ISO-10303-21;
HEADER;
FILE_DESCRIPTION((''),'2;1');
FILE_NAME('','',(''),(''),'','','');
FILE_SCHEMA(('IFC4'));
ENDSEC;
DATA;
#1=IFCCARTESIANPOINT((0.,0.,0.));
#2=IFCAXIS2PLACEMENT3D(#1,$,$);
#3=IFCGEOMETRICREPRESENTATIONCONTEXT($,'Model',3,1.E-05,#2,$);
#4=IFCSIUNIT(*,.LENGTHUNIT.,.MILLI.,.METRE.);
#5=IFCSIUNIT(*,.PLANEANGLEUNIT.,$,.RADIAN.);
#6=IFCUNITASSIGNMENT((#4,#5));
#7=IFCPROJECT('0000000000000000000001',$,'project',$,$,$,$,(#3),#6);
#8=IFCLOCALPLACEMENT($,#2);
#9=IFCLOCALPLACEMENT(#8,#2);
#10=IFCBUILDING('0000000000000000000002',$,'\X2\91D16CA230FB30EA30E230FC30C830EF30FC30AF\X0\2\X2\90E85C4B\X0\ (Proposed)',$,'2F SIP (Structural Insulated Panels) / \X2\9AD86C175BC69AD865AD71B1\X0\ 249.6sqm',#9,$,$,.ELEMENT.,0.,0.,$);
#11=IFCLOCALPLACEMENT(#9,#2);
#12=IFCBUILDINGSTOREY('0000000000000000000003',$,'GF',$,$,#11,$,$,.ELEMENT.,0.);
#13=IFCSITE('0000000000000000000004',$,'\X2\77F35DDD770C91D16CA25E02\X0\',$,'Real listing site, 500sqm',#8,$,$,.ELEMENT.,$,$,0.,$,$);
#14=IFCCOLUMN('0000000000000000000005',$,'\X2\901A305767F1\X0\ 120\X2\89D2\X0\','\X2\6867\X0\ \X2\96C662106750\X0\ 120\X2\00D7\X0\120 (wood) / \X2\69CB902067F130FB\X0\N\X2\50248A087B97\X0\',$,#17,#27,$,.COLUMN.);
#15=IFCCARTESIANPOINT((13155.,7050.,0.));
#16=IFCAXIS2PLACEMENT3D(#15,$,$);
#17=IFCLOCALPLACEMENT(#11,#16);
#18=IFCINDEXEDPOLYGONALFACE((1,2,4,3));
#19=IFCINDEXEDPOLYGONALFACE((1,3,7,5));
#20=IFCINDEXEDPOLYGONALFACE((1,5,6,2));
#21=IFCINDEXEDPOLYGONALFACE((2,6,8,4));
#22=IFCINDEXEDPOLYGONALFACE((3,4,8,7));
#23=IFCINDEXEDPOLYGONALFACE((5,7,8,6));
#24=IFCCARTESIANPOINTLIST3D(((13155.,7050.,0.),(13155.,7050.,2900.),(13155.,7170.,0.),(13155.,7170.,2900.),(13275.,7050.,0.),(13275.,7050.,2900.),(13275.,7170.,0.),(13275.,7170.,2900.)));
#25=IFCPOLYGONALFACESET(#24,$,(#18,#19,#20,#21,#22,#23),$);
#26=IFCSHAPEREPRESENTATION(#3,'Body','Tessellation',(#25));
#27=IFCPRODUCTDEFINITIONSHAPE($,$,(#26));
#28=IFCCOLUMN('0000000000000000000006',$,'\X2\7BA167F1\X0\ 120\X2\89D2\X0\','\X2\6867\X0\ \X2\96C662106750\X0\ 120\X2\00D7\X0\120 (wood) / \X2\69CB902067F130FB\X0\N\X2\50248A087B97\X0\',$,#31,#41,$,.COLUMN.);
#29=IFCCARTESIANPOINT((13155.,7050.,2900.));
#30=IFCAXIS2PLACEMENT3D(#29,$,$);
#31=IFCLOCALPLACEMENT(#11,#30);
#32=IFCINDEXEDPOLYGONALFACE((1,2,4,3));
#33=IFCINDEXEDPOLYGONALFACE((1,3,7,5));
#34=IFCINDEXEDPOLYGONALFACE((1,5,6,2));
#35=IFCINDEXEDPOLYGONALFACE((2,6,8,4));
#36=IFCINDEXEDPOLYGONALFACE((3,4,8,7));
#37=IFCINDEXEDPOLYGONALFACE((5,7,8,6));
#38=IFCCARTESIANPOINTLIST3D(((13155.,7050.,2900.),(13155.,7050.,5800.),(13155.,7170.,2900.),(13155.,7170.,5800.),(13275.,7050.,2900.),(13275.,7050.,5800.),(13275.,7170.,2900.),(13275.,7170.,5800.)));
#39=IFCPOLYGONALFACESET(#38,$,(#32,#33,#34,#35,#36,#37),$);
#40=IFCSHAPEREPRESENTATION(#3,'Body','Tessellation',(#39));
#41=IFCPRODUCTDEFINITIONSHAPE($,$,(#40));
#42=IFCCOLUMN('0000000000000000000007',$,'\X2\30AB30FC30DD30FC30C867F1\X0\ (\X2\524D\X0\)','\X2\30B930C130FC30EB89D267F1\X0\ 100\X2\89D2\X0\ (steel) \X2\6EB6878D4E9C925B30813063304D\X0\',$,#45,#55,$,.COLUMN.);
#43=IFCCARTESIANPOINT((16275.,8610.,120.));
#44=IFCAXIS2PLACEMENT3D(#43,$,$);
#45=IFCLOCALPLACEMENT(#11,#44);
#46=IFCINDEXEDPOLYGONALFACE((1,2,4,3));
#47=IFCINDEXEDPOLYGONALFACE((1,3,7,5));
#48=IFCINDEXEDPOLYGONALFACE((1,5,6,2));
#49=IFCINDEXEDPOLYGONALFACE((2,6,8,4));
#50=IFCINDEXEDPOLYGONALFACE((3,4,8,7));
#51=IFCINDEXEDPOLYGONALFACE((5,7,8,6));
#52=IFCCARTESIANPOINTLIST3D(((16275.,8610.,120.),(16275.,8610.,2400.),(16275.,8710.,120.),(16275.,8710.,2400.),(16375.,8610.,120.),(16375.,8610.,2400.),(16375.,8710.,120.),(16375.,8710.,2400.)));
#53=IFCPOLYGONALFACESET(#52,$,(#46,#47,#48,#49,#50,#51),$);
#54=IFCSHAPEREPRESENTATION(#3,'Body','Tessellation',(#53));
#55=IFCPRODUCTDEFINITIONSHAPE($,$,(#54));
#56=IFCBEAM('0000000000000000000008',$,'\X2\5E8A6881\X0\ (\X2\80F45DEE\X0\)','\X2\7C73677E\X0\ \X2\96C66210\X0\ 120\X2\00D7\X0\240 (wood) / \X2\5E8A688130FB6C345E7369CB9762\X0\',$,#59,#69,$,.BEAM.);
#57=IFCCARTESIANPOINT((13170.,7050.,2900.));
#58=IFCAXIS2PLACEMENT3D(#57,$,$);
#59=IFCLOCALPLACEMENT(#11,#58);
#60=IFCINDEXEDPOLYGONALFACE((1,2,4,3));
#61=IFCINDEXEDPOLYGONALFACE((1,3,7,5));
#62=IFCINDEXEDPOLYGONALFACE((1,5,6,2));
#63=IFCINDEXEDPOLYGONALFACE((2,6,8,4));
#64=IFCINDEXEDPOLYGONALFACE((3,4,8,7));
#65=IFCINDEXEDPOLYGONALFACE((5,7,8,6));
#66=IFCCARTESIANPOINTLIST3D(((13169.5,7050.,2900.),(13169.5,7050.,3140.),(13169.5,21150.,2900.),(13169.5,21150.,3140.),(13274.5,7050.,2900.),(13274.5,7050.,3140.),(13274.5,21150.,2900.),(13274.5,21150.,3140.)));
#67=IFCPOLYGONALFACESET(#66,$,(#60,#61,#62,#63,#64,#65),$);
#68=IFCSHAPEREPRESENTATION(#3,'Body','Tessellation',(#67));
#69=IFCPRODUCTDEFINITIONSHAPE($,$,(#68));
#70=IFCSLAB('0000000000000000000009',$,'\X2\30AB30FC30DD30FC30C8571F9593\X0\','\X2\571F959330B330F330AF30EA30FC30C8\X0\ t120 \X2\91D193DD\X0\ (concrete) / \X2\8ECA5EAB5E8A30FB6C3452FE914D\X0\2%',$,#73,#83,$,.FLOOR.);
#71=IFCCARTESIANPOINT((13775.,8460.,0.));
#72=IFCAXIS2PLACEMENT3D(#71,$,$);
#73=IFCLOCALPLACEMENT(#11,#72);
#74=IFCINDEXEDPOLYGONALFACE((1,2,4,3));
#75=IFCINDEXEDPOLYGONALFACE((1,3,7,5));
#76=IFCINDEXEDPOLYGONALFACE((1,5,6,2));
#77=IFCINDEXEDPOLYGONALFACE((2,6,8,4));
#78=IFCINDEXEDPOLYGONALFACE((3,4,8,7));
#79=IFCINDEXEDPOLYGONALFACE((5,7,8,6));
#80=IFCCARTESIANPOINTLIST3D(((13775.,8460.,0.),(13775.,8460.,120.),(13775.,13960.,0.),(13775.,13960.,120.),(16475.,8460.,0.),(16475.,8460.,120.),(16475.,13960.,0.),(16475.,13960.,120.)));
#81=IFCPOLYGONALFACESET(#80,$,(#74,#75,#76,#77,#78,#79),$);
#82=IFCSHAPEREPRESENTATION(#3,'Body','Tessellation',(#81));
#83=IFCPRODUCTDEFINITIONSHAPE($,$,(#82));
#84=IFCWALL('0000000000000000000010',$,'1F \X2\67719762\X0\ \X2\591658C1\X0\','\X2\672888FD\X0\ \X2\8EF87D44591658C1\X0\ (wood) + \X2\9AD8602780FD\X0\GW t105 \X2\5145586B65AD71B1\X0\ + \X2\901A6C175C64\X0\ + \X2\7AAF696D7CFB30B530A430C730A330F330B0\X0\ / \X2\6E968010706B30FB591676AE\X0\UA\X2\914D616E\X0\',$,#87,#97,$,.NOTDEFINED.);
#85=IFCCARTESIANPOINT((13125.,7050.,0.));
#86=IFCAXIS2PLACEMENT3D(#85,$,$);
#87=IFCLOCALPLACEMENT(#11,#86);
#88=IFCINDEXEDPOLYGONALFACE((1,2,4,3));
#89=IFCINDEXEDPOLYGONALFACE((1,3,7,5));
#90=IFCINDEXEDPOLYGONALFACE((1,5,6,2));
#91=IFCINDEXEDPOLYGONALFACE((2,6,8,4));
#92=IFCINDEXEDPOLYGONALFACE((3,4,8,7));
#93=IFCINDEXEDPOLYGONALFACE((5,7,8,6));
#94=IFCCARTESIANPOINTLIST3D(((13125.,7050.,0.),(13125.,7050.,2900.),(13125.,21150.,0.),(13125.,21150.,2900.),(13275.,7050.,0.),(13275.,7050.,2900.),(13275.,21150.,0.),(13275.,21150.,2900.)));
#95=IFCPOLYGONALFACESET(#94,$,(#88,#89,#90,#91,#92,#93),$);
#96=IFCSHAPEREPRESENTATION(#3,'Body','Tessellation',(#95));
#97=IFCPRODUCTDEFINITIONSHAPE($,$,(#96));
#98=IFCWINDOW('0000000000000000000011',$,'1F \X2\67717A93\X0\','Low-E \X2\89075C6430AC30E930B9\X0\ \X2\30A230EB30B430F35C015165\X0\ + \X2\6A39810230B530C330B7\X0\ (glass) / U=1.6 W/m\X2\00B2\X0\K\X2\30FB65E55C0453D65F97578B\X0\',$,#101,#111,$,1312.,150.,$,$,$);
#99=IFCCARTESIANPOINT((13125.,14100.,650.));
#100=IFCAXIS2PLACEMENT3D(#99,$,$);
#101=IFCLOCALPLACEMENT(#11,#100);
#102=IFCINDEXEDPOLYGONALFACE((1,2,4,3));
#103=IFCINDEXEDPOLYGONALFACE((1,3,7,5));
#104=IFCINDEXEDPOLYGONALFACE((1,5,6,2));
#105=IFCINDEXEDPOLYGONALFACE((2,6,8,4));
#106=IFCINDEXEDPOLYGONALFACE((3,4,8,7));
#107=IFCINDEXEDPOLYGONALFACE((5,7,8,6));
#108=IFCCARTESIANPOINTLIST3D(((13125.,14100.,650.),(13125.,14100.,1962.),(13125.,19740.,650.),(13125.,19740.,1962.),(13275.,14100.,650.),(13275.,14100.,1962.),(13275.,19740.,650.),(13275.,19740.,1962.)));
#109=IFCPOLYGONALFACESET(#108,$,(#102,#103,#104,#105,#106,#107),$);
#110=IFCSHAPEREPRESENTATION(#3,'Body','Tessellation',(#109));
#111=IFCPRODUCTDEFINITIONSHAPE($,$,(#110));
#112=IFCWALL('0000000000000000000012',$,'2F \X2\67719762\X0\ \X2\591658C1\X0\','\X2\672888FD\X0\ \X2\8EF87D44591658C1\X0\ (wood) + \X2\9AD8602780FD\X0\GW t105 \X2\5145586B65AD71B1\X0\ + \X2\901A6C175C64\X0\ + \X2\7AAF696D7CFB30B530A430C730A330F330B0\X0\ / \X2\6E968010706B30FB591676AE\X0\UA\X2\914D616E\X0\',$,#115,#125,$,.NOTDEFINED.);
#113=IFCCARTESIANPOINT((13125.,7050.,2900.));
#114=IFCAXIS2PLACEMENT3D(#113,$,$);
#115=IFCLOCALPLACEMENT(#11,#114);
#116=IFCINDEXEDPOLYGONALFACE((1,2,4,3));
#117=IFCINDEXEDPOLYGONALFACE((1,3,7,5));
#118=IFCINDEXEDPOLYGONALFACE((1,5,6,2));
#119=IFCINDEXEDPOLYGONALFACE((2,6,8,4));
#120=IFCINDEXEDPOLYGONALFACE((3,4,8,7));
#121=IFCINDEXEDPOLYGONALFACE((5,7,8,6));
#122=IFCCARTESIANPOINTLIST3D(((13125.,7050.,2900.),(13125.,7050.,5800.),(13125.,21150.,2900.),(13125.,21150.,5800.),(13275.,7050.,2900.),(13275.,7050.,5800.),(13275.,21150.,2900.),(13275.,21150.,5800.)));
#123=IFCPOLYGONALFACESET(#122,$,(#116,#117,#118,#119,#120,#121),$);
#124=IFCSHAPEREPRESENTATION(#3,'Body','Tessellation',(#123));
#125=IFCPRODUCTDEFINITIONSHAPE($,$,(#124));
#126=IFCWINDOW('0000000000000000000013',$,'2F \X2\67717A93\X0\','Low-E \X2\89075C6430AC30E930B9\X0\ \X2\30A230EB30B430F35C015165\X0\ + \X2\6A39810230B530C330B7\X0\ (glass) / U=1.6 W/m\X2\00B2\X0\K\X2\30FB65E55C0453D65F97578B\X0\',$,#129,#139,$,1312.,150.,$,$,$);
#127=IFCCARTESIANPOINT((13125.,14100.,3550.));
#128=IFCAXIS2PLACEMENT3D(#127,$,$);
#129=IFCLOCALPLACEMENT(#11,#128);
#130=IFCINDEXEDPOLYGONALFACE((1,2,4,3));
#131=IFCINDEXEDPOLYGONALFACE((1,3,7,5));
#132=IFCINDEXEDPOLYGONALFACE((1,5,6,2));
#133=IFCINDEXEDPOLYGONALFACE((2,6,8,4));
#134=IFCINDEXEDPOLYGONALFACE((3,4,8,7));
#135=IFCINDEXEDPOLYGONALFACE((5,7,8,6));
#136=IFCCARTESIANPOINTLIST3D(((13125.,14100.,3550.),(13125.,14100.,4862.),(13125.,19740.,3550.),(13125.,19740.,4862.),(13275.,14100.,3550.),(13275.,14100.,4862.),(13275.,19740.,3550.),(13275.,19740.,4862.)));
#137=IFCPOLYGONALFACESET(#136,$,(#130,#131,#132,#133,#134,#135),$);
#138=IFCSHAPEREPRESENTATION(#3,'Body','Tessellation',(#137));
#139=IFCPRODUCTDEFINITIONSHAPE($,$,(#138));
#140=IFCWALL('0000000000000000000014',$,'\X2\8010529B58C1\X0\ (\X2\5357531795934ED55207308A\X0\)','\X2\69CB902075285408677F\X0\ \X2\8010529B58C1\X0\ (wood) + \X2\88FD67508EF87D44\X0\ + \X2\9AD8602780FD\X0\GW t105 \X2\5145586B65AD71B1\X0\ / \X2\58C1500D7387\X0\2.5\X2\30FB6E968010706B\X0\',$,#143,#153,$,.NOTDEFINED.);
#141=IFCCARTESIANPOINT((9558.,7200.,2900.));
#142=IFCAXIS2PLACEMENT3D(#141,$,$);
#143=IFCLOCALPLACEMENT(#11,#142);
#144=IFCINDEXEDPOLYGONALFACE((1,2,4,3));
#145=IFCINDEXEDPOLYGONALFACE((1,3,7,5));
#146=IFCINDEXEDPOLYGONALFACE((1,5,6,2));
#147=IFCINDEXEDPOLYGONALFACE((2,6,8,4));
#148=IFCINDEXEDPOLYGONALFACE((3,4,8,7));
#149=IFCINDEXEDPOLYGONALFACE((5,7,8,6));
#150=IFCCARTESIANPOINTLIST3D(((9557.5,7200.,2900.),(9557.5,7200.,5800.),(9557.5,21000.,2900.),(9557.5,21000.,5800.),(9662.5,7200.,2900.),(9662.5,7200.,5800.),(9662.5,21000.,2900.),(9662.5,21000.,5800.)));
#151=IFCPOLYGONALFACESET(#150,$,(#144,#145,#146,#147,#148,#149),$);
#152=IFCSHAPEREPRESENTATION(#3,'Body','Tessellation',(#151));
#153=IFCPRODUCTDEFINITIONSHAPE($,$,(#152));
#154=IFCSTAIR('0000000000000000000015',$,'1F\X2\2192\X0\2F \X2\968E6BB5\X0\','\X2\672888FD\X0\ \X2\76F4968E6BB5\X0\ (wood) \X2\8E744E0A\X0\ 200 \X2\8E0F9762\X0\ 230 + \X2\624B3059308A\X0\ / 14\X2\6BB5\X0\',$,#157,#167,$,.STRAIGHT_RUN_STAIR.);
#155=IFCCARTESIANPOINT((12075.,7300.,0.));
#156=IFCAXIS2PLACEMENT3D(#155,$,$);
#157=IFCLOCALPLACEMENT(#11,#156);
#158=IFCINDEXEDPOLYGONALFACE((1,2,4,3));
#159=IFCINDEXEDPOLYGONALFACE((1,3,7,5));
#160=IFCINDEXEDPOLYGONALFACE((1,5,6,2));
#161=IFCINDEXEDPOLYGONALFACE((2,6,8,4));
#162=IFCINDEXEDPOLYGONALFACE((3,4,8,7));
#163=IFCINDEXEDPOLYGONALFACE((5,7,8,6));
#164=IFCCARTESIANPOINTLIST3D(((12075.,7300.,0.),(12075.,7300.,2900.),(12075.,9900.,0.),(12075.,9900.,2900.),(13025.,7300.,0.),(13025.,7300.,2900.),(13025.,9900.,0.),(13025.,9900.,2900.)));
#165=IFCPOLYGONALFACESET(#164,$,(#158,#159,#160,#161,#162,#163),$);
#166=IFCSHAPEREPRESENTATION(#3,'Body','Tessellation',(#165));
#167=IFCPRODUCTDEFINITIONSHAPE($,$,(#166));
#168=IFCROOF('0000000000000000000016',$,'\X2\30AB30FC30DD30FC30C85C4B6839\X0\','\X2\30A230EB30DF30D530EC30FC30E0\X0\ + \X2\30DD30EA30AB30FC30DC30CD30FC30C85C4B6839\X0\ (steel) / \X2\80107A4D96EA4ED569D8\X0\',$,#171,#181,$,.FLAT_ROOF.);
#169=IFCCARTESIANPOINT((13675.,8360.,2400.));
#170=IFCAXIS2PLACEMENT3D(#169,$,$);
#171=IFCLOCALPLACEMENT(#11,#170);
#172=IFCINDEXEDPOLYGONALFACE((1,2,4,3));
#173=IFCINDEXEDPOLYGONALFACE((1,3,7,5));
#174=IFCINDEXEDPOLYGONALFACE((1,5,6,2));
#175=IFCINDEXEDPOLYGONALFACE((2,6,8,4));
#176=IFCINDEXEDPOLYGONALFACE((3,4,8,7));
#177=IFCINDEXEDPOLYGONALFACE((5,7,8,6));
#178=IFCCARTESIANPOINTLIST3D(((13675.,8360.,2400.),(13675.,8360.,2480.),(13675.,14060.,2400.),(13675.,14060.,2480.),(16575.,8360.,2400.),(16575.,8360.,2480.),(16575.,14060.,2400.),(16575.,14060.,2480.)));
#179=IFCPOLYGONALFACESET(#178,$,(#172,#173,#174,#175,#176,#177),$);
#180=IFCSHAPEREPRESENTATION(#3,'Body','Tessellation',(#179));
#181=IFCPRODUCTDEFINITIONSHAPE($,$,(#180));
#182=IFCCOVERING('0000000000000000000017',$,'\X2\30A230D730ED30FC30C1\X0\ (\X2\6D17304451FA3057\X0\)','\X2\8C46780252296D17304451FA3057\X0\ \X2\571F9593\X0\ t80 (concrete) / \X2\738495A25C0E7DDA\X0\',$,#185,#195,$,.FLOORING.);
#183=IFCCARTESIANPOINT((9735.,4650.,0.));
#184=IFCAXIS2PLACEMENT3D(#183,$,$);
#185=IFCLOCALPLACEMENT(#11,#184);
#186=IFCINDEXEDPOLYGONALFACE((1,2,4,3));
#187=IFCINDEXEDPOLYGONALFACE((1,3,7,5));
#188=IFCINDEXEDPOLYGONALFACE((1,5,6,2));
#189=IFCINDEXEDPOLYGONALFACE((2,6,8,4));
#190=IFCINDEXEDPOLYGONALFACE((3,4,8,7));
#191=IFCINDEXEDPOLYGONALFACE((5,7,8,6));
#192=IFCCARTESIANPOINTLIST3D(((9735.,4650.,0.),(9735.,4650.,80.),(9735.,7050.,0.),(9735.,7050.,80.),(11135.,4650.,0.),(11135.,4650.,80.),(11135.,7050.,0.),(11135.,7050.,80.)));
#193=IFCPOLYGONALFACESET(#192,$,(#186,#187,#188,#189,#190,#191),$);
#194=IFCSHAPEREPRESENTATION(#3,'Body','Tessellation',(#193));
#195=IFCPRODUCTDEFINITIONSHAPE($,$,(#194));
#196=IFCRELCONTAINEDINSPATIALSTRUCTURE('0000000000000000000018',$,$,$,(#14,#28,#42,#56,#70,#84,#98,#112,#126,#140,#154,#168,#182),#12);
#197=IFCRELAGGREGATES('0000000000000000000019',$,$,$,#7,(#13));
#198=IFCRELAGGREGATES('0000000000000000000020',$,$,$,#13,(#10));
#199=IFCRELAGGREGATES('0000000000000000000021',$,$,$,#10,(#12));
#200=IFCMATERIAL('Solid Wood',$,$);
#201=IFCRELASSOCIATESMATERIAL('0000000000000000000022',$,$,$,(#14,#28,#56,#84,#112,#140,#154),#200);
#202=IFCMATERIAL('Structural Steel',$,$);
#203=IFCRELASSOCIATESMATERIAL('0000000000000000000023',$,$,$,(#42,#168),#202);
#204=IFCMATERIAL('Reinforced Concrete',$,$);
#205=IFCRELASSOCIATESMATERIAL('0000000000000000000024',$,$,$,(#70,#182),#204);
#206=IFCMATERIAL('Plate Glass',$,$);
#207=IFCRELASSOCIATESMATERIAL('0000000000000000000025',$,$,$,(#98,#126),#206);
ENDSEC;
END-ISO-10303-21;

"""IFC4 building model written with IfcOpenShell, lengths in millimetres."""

from ifc_helpers import new_model, si_unit, frame, frame_2d, origin, place, context, project, spatial, rectangle, extrude, material, element, fill, save


model = new_model("IFC4")

# Units and contexts
model_context = context("Model", 3, precision=1e-05, world=origin())
ifc_project = project(units=[si_unit("LENGTHUNIT", "METRE", prefix="MILLI"), si_unit("PLANEANGLEUNIT", "RADIAN")], contexts=[model_context])

# Site, building, storey
site_placement = place(None, origin())
site = spatial("IfcSite", under=ifc_project, at=site_placement, Name="石川県金沢市", ObjectType="Real listing site, 500sqm", CompositionType="ELEMENT", RefElevation=0.0)
building_placement = place(site_placement, origin())
building = spatial("IfcBuilding", under=site, at=building_placement, Name="金沢・リモートワーク2部屋 (Proposed)", ObjectType="2F SIP (Structural Insulated Panels) / 高気密高断熱 249.6sqm", CompositionType="ELEMENT", ElevationOfRefHeight=0.0, ElevationOfTerrain=0.0)
storey_placement = place(building_placement, origin())
storey = spatial("IfcBuildingStorey", under=building, at=storey_placement, Name="GF", CompositionType="ELEMENT", Elevation=0.0)

# Columns
ifc_material_1 = material(Name="Solid Wood")
column_1_placement = place(storey_placement, frame((13155.0, 7050.0, 0.0)))
element("IfcColumn", 1, at=column_1_placement, inside=storey, material=ifc_material_1, Name="通し柱 120角", Description="桧 集成材 120×120 (wood) / 構造柱・N値計算", PredefinedType="COLUMN", context=model_context, shape_type="SweptSolid", body=[
    extrude(rectangle(XDim=120.0, YDim=120.0, at=frame_2d((60.0, 60.0))), frame((13155.0, 7050.0, 0.0)), (0.0, 0.0, 1.0), 2900.0),
])
column_2_placement = place(storey_placement, frame((13155.0, 7050.0, 2900.0)))
element("IfcColumn", 2, at=column_2_placement, inside=storey, material=ifc_material_1, Name="管柱 120角", Description="桧 集成材 120×120 (wood) / 構造柱・N値計算", PredefinedType="COLUMN", context=model_context, shape_type="SweptSolid", body=[
    extrude(rectangle(XDim=120.0, YDim=120.0, at=frame_2d((60.0, 60.0))), frame((13155.0, 7050.0, 2900.0)), (0.0, 0.0, 1.0), 2900.0),
])
ifc_material_2 = material(Name="Structural Steel")
column_3_placement = place(storey_placement, frame((16275.0, 8610.0, 120.0)))
element("IfcColumn", 3, at=column_3_placement, inside=storey, material=ifc_material_2, Name="カーポート柱 (前)", Description="スチール角柱 100角 (steel) 溶融亜鉛めっき", PredefinedType="COLUMN", context=model_context, shape_type="SweptSolid", body=[
    extrude(rectangle(XDim=100.0, YDim=100.0, at=frame_2d((50.0, 50.0))), frame((16275.0, 8610.0, 120.0)), (0.0, 0.0, 1.0), 2280.0),
])

# Beam
beam_1_placement = place(storey_placement, frame((13170.0, 7050.0, 2900.0)))
element("IfcBeam", 4, at=beam_1_placement, inside=storey, material=ifc_material_1, Name="床梁 (胴差)", Description="米松 集成 120×240 (wood) / 床梁・水平構面", PredefinedType="BEAM", context=model_context, shape_type="SweptSolid", body=[
    extrude(rectangle(XDim=105.0, YDim=14100.0, at=frame_2d((52.0, 7050.0))), frame((13170.0, 7050.0, 2900.0)), (0.0, 0.0, 1.0), 240.0),
])

# Slab
ifc_material_3 = material(Name="Reinforced Concrete")
slab_placement = place(storey_placement, frame((13775.0, 8460.0, 0.0)))
element("IfcSlab", 5, at=slab_placement, inside=storey, material=ifc_material_3, Name="カーポート土間", Description="土間コンクリート t120 金鏝 (concrete) / 車庫床・水勾配2%", PredefinedType="FLOOR", context=model_context, shape_type="SweptSolid", body=[
    extrude(rectangle(XDim=2700.0, YDim=5500.0, at=frame_2d((1350.0, 2750.0))), frame((13775.0, 8460.0, 0.0)), (0.0, 0.0, 1.0), 120.0),
])

# Wall, opening, window
wall_1_placement = place(storey_placement, frame((13125.0, 7050.0, 0.0)))
wall_1 = element("IfcWall", 6, at=wall_1_placement, inside=storey, material=ifc_material_1, Name="1F 東面 外壁", Description="木製 軸組外壁 (wood) + 高性能GW t105 充填断熱 + 通気層 + 窯業系サイディング / 準耐火・外皮UA配慮", PredefinedType="NOTDEFINED", context=model_context, shape_type="SweptSolid", body=[
    extrude(rectangle(XDim=150.0, YDim=14100.0, at=frame_2d((75.0, 7050.0))), frame((13125.0, 7050.0, 0.0)), (0.0, 0.0, 1.0), 2900.0),
])
opening_1_placement = place(storey_placement, frame((13125.0, 14100.0, 650.0)))
opening_1 = element("IfcOpeningElement", 7, at=opening_1_placement, cuts=wall_1, PredefinedType="NOTDEFINED", context=model_context, shape_type="SweptSolid", body=[
    extrude(rectangle(XDim=150.0, YDim=5640.0, at=frame_2d((75.0, 2820.0))), frame((13125.0, 14100.0, 650.0)), (0.0, 0.0, 1.0), 1312.0),
])
ifc_material_4 = material(Name="Plate Glass")
window_1_placement = place(storey_placement, frame((13125.0, 14100.0, 650.0)))
window_1 = element("IfcWindow", 8, at=window_1_placement, inside=storey, material=ifc_material_4, Name="1F 東窓", Description="Low-E 複層ガラス アルゴン封入 + 樹脂サッシ (glass) / U=1.6 W/m²K・日射取得型", OverallHeight=1312.0, OverallWidth=150.0, context=model_context, shape_type="SweptSolid", body=[
    extrude(rectangle(XDim=150.0, YDim=5640.0, at=frame_2d((75.0, 2820.0))), frame((13125.0, 14100.0, 650.0)), (0.0, 0.0, 1.0), 1312.0),
])
fill(opening_1, window_1)

# Wall, opening, window
wall_2_placement = place(storey_placement, frame((13125.0, 7050.0, 2900.0)))
wall_2 = element("IfcWall", 9, at=wall_2_placement, inside=storey, material=ifc_material_1, Name="2F 東面 外壁", Description="木製 軸組外壁 (wood) + 高性能GW t105 充填断熱 + 通気層 + 窯業系サイディング / 準耐火・外皮UA配慮", PredefinedType="NOTDEFINED", context=model_context, shape_type="SweptSolid", body=[
    extrude(rectangle(XDim=150.0, YDim=14100.0, at=frame_2d((75.0, 7050.0))), frame((13125.0, 7050.0, 2900.0)), (0.0, 0.0, 1.0), 2900.0),
])
opening_2_placement = place(storey_placement, frame((13125.0, 14100.0, 3550.0)))
opening_2 = element("IfcOpeningElement", 10, at=opening_2_placement, cuts=wall_2, PredefinedType="NOTDEFINED", context=model_context, shape_type="SweptSolid", body=[
    extrude(rectangle(XDim=150.0, YDim=5640.0, at=frame_2d((75.0, 2820.0))), frame((13125.0, 14100.0, 3550.0)), (0.0, 0.0, 1.0), 1312.0),
])
window_2_placement = place(storey_placement, frame((13125.0, 14100.0, 3550.0)))
window_2 = element("IfcWindow", 11, at=window_2_placement, inside=storey, material=ifc_material_4, Name="2F 東窓", Description="Low-E 複層ガラス アルゴン封入 + 樹脂サッシ (glass) / U=1.6 W/m²K・日射取得型", OverallHeight=1312.0, OverallWidth=150.0, context=model_context, shape_type="SweptSolid", body=[
    extrude(rectangle(XDim=150.0, YDim=5640.0, at=frame_2d((75.0, 2820.0))), frame((13125.0, 14100.0, 3550.0)), (0.0, 0.0, 1.0), 1312.0),
])
fill(opening_2, window_2)

# Wall
wall_3_placement = place(storey_placement, frame((9558.0, 7200.0, 2900.0)))
element("IfcWall", 12, at=wall_3_placement, inside=storey, material=ifc_material_1, Name="耐力壁 (南北間仕切り)", Description="構造用合板 耐力壁 (wood) + 製材軸組 + 高性能GW t105 充填断熱 / 壁倍率2.5・準耐火", PredefinedType="NOTDEFINED", context=model_context, shape_type="SweptSolid", body=[
    extrude(rectangle(XDim=105.0, YDim=13800.0, at=frame_2d((52.0, 6900.0))), frame((9558.0, 7200.0, 2900.0)), (0.0, 0.0, 1.0), 2900.0),
])

# Stair
stair_placement = place(storey_placement, frame((12075.0, 7300.0, 0.0)))
element("IfcStair", 13, at=stair_placement, inside=storey, material=ifc_material_1, Name="1F→2F 階段", Description="木製 直階段 (wood) 蹴上 200 踏面 230 + 手すり / 14段", PredefinedType="STRAIGHT_RUN_STAIR", context=model_context, shape_type="SweptSolid", body=[
    extrude(rectangle(XDim=950.0, YDim=2600.0, at=frame_2d((475.0, 1300.0))), frame((12075.0, 7300.0, 0.0)), (0.0, 0.0, 1.0), 2900.0),
])

# Roof
roof_placement = place(storey_placement, frame((13675.0, 8360.0, 2400.0)))
element("IfcRoof", 14, at=roof_placement, inside=storey, material=ifc_material_2, Name="カーポート屋根", Description="アルミフレーム + ポリカーボネート屋根 (steel) / 耐積雪仕様", PredefinedType="FLAT_ROOF", context=model_context, shape_type="SweptSolid", body=[
    extrude(rectangle(XDim=2900.0, YDim=5700.0, at=frame_2d((1450.0, 2850.0))), frame((13675.0, 8360.0, 2400.0)), (0.0, 0.0, 1.0), 80.0),
])

# Covering
covering_placement = place(storey_placement, frame((9735.0, 4650.0, 0.0)))
element("IfcCovering", 15, at=covering_placement, inside=storey, material=ifc_material_3, Name="アプローチ (洗い出し)", Description="豆砂利洗い出し 土間 t80 (concrete) / 玄関導線", PredefinedType="FLOORING", context=model_context, shape_type="SweptSolid", body=[
    extrude(rectangle(XDim=1400.0, YDim=2400.0, at=frame_2d((700.0, 1200.0))), frame((9735.0, 4650.0, 0.0)), (0.0, 0.0, 1.0), 80.0),
])

save(model, "model.ifc")
